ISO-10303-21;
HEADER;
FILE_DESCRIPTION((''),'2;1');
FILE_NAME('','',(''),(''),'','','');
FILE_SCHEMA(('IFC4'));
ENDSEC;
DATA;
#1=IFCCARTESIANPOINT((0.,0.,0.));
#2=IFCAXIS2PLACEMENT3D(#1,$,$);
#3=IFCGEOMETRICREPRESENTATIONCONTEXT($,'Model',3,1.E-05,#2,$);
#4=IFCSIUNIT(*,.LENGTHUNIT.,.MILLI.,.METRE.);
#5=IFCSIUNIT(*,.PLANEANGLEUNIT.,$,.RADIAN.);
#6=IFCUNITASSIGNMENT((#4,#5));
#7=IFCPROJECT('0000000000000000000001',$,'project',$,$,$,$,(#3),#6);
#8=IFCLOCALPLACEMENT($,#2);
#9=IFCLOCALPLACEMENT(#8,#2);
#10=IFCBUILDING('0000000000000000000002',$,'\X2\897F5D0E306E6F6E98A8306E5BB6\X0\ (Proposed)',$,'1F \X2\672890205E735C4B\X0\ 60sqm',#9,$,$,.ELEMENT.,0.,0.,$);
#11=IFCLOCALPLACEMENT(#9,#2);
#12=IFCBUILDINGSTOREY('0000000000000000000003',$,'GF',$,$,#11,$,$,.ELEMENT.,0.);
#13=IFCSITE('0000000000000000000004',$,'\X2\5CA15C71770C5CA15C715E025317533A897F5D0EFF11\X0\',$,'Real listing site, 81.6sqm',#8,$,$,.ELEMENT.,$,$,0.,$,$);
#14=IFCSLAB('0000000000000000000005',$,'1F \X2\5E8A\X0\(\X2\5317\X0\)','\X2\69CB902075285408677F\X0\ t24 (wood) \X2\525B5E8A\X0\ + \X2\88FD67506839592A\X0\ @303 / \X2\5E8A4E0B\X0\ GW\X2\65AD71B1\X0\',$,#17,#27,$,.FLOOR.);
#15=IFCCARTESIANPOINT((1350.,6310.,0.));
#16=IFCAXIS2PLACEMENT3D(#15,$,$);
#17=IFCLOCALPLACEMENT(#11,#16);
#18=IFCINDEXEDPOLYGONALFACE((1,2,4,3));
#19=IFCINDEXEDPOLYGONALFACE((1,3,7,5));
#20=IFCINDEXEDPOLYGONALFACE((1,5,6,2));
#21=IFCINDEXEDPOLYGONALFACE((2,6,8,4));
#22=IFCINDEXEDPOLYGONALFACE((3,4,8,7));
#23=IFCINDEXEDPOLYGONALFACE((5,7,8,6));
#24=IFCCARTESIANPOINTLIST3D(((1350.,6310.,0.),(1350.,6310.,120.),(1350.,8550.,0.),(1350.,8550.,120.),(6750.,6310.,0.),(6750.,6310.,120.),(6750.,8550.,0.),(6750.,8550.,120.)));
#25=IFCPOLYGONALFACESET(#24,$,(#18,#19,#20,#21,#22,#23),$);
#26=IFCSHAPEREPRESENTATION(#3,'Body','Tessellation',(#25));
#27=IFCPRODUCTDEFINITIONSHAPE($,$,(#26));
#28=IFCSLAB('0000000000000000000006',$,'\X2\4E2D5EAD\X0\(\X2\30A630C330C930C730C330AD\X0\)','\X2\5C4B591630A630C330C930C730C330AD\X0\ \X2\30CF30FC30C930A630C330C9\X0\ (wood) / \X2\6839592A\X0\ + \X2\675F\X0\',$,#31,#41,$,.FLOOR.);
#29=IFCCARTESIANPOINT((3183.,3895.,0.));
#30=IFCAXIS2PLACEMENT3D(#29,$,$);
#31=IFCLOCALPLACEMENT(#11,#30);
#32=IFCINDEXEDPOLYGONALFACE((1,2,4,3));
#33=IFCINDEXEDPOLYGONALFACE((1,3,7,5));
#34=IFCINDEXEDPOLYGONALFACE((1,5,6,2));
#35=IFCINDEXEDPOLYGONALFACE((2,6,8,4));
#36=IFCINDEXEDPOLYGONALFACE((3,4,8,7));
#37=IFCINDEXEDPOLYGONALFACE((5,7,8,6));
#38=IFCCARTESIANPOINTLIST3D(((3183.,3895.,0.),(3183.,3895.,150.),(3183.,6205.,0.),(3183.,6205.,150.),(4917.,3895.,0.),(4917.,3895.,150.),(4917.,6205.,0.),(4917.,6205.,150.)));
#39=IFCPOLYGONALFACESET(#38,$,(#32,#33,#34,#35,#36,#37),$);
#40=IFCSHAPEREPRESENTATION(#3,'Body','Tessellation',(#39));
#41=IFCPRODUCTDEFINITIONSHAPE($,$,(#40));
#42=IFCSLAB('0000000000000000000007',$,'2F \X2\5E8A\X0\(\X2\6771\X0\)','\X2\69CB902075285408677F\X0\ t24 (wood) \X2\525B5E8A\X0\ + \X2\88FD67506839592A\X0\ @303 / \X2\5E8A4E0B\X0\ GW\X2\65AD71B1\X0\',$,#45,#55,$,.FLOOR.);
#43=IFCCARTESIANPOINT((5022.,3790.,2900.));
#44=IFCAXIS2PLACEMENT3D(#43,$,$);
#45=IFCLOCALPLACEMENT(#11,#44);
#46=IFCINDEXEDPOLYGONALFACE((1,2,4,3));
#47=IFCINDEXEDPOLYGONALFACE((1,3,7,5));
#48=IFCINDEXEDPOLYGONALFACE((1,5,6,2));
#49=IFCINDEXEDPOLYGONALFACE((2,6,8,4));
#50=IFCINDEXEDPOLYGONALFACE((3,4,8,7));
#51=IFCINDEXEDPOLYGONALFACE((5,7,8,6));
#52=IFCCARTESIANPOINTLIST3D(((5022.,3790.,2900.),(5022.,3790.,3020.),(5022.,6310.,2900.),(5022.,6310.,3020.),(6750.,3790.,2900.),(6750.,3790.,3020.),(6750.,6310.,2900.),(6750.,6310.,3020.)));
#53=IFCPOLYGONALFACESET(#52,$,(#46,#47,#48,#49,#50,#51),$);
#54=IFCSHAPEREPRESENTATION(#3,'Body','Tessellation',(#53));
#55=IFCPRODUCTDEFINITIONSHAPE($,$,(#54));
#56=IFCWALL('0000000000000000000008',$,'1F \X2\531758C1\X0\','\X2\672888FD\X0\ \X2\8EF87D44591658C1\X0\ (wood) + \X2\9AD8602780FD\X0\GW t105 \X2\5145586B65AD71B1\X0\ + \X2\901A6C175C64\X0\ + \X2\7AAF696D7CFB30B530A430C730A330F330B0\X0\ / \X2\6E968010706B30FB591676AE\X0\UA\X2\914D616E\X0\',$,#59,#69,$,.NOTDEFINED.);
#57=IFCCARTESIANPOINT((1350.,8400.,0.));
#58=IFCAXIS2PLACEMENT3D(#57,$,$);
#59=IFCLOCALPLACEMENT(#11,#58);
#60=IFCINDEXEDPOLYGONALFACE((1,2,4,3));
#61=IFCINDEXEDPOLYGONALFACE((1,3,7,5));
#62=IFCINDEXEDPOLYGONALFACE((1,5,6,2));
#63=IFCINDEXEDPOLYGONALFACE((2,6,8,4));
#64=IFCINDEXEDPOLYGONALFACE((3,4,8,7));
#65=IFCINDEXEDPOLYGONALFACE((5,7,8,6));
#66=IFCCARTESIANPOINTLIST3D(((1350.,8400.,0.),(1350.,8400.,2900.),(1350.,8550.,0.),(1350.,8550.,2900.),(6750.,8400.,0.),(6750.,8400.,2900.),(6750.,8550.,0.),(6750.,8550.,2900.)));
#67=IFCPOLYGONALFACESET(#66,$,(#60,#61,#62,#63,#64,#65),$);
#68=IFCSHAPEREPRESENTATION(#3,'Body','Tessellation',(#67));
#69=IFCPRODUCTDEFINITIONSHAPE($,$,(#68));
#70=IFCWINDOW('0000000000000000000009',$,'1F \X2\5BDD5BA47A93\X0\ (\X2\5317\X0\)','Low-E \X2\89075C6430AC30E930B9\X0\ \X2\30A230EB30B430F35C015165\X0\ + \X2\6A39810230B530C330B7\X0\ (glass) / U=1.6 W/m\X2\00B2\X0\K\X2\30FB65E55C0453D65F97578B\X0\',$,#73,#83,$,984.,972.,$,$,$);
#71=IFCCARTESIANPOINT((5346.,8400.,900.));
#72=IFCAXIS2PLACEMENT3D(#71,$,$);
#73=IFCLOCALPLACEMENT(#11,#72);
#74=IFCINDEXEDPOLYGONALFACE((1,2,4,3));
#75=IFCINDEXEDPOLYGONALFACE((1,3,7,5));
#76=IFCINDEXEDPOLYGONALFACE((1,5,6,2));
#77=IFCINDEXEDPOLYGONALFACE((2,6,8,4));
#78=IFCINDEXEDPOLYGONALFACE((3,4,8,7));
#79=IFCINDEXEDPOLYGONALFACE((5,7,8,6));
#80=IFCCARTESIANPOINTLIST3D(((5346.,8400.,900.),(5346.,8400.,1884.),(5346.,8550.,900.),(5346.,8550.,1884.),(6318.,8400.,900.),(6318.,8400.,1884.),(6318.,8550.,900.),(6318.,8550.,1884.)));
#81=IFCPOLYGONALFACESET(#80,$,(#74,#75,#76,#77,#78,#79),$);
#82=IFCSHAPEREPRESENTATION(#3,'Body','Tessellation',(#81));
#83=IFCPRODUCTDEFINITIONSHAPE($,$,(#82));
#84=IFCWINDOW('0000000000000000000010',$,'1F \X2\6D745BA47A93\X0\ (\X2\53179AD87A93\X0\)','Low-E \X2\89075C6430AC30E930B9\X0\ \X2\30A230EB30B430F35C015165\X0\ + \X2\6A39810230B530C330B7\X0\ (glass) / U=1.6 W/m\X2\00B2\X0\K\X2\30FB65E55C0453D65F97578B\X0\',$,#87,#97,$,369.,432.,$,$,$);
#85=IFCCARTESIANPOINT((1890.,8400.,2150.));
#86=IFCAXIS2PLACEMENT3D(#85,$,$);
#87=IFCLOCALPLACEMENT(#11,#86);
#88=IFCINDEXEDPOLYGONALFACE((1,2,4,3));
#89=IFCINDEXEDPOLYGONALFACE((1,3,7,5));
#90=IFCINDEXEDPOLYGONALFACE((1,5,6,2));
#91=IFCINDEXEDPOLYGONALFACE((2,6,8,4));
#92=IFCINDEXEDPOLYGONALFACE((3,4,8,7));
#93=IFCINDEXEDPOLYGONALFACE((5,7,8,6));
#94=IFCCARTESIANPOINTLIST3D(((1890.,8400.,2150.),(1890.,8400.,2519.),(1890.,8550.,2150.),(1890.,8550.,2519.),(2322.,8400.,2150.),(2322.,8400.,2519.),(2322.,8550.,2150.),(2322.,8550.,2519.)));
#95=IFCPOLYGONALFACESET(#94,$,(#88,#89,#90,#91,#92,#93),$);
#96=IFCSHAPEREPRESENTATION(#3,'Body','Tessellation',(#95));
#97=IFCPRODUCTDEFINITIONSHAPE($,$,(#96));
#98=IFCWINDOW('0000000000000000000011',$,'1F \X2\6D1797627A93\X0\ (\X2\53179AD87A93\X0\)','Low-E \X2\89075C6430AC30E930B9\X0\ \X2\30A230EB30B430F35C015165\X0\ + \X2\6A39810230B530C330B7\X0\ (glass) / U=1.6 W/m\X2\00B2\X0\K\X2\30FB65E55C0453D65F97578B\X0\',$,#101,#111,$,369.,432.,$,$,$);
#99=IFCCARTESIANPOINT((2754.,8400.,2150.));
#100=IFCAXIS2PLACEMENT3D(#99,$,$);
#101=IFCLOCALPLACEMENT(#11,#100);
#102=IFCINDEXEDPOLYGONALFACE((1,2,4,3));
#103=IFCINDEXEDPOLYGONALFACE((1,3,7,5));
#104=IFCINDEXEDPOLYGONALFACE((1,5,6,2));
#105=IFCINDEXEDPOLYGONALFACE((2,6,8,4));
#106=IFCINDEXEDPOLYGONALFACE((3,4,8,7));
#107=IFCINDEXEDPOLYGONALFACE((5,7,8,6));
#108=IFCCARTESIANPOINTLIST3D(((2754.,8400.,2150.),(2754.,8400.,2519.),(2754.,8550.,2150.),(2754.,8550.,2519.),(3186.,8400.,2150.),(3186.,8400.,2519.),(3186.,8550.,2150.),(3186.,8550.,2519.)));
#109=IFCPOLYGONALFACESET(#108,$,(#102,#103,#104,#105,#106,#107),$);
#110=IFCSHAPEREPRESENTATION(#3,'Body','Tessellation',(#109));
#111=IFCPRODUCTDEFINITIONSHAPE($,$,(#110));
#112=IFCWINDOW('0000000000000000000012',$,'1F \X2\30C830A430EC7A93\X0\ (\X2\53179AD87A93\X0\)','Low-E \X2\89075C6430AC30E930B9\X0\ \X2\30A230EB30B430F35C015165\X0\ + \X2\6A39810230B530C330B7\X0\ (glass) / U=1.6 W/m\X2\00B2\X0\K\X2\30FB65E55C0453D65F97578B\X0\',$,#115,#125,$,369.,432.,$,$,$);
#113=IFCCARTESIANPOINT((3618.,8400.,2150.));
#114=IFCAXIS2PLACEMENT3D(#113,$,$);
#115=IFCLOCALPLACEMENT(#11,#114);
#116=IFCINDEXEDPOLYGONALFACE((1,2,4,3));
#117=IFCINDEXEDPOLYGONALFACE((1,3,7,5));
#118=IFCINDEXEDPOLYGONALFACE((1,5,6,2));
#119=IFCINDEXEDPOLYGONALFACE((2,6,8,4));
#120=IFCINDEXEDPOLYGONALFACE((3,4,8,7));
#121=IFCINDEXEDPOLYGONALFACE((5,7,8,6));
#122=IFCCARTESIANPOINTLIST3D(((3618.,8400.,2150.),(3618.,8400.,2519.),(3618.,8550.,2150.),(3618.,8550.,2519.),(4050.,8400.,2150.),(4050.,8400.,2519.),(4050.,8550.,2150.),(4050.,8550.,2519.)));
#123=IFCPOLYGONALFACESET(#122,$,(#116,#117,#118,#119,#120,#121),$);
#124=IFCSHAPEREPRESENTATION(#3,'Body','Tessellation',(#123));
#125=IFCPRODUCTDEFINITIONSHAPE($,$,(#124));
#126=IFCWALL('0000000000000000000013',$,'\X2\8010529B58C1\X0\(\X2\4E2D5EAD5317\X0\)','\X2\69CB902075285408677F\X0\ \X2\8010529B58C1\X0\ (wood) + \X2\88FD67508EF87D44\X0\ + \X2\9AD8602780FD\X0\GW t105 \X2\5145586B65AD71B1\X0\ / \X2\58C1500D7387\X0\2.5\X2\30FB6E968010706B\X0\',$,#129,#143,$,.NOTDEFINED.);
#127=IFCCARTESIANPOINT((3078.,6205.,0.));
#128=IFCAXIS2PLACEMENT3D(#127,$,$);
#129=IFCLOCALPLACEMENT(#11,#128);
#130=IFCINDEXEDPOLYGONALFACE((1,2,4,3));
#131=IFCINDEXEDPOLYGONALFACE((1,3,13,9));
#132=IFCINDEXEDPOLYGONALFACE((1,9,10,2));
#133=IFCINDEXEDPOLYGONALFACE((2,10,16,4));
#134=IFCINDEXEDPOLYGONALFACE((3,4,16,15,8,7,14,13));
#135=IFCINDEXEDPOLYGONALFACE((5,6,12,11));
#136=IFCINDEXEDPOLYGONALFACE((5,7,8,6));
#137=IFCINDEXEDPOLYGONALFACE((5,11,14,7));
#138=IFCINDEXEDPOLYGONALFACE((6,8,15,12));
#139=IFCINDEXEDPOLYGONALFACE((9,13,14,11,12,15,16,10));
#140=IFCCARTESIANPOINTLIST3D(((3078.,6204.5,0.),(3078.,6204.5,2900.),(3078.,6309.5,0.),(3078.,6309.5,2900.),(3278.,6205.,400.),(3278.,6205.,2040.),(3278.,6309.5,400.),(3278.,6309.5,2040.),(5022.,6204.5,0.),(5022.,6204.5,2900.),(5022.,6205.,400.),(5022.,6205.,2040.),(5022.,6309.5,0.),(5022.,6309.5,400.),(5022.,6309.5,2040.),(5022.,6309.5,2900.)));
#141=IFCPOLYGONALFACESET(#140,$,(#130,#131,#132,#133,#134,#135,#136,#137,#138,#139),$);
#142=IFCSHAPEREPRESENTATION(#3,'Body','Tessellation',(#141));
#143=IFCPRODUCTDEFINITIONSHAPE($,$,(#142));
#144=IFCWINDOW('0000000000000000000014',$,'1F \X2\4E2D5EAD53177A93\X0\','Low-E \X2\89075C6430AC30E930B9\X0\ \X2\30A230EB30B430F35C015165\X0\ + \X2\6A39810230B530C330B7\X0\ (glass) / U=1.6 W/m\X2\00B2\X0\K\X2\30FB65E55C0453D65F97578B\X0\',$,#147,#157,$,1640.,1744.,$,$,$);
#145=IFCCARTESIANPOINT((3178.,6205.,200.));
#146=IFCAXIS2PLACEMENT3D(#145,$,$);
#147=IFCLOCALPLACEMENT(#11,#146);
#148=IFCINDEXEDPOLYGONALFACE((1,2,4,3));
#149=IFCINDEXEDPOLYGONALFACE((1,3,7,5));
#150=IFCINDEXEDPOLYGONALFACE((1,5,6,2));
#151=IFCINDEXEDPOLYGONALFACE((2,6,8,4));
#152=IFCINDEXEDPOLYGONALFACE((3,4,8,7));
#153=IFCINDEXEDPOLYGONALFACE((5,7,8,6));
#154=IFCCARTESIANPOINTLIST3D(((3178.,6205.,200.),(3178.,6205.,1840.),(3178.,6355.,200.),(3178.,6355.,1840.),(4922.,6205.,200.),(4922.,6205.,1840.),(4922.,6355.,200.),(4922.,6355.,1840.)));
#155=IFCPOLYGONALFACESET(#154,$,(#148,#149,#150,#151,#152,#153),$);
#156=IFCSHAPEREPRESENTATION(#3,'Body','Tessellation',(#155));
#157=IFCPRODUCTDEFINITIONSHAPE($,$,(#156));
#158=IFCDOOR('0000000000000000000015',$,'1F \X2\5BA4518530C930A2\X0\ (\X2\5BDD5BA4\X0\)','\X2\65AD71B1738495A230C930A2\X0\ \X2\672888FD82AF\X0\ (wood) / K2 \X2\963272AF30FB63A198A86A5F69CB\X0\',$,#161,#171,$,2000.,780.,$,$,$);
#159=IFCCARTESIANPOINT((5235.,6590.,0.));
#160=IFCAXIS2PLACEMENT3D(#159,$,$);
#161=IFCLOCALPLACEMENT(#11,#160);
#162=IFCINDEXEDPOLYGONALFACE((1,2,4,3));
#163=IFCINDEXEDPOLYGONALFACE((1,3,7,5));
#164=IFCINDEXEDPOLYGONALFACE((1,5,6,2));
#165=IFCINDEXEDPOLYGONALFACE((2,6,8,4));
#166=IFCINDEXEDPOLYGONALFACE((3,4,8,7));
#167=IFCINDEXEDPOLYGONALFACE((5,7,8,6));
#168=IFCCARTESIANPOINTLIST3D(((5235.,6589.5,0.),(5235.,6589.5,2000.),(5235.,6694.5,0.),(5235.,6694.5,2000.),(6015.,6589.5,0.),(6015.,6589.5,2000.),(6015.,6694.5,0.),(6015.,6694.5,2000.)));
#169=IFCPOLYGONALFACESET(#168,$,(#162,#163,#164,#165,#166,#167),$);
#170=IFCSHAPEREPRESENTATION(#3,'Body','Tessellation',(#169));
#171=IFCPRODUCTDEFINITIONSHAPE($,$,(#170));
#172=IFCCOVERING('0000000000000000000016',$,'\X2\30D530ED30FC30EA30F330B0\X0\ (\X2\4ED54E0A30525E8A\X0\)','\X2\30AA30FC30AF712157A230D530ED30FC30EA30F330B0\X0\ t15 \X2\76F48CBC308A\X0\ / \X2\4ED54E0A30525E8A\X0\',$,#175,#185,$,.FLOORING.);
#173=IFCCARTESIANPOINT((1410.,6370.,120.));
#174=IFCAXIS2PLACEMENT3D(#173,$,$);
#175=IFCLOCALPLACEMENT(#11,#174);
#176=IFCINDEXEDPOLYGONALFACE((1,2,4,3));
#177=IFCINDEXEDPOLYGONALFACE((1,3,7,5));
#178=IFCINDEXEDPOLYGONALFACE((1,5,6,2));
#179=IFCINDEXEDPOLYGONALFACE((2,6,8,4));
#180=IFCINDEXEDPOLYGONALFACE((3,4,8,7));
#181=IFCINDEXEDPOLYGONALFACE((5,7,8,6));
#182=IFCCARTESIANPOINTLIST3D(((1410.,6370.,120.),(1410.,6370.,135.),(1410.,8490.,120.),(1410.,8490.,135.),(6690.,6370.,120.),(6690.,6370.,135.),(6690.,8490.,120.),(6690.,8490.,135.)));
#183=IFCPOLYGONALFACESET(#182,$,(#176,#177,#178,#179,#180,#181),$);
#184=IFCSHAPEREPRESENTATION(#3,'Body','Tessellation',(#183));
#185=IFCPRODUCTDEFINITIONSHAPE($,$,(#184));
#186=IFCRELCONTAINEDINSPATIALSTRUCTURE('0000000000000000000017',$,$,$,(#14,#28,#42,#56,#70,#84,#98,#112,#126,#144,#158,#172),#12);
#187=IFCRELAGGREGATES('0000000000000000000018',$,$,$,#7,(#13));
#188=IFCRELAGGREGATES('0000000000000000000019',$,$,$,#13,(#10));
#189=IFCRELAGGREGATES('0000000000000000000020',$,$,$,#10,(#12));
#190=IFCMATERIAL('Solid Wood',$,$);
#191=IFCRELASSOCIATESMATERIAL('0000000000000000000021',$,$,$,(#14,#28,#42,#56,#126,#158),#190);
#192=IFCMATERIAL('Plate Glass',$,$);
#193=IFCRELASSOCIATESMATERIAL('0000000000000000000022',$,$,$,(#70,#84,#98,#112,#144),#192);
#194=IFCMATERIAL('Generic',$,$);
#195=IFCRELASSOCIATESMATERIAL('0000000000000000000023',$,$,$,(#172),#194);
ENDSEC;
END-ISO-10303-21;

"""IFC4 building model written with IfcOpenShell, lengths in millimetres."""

from ifc_helpers import new_model, si_unit, frame, frame_2d, origin, place, context, project, spatial, rectangle, extrude, material, element, fill, save


model = new_model("IFC4")

# Units and contexts
model_context = context("Model", 3, precision=1e-05, world=origin())
ifc_project = project(units=[si_unit("LENGTHUNIT", "METRE", prefix="MILLI"), si_unit("PLANEANGLEUNIT", "RADIAN")], contexts=[model_context])

# Site, building, storey
site_placement = place(None, origin())
site = spatial("IfcSite", under=ifc_project, at=site_placement, Name="岡山県岡山市北区西崎１", ObjectType="Real listing site, 81.6sqm", CompositionType="ELEMENT", RefElevation=0.0)
building_placement = place(site_placement, origin())
building = spatial("IfcBuilding", under=site, at=building_placement, Name="西崎の潮風の家 (Proposed)", ObjectType="1F 木造平屋 60sqm", CompositionType="ELEMENT", ElevationOfRefHeight=0.0, ElevationOfTerrain=0.0)
storey_placement = place(building_placement, origin())
storey = spatial("IfcBuildingStorey", under=building, at=storey_placement, Name="GF", CompositionType="ELEMENT", Elevation=0.0)

# Slabs
ifc_material_1 = material(Name="Solid Wood")
slab_1_placement = place(storey_placement, frame((1350.0, 6310.0, 0.0)))
element("IfcSlab", 1, at=slab_1_placement, inside=storey, material=ifc_material_1, Name="1F 床(北)", Description="構造用合板 t24 (wood) 剛床 + 製材根太 @303 / 床下 GW断熱", PredefinedType="FLOOR", context=model_context, shape_type="SweptSolid", body=[
    extrude(rectangle(XDim=5400.0, YDim=2240.0, at=frame_2d((2700.0, 1120.0))), frame((1350.0, 6310.0, 0.0)), (0.0, 0.0, 1.0), 120.0),
])
slab_2_placement = place(storey_placement, frame((3183.0, 3895.0, 0.0)))
element("IfcSlab", 2, at=slab_2_placement, inside=storey, material=ifc_material_1, Name="中庭(ウッドデッキ)", Description="屋外ウッドデッキ ハードウッド (wood) / 根太 + 束", PredefinedType="FLOOR", context=model_context, shape_type="SweptSolid", body=[
    extrude(rectangle(XDim=1734.0, YDim=2310.0, at=frame_2d((867.0, 1155.0))), frame((3183.0, 3895.0, 0.0)), (0.0, 0.0, 1.0), 150.0),
])
slab_3_placement = place(storey_placement, frame((5022.0, 3790.0, 2900.0)))
element("IfcSlab", 3, at=slab_3_placement, inside=storey, material=ifc_material_1, Name="2F 床(東)", Description="構造用合板 t24 (wood) 剛床 + 製材根太 @303 / 床下 GW断熱", PredefinedType="FLOOR", context=model_context, shape_type="SweptSolid", body=[
    extrude(rectangle(XDim=1728.0, YDim=2520.0, at=frame_2d((864.0, 1260.0))), frame((5022.0, 3790.0, 2900.0)), (0.0, 0.0, 1.0), 120.0),
])

# Wall, openings, windows
wall_1_placement = place(storey_placement, frame((1350.0, 8400.0, 0.0)))
wall_1 = element("IfcWall", 4, at=wall_1_placement, inside=storey, material=ifc_material_1, Name="1F 北壁", Description="木製 軸組外壁 (wood) + 高性能GW t105 充填断熱 + 通気層 + 窯業系サイディング / 準耐火・外皮UA配慮", PredefinedType="NOTDEFINED", context=model_context, shape_type="SweptSolid", body=[
    extrude(rectangle(XDim=5400.0, YDim=150.0, at=frame_2d((2700.0, 75.0))), frame((1350.0, 8400.0, 0.0)), (0.0, 0.0, 1.0), 2900.0),
])
opening_1_placement = place(storey_placement, frame((5346.0, 8400.0, 900.0)))
opening_1 = element("IfcOpeningElement", 5, at=opening_1_placement, cuts=wall_1, PredefinedType="NOTDEFINED", context=model_context, shape_type="SweptSolid", body=[
    extrude(rectangle(XDim=972.0, YDim=150.0, at=frame_2d((486.0, 75.0))), frame((5346.0, 8400.0, 900.0)), (0.0, 0.0, 1.0), 984.0),
])
opening_2_placement = place(storey_placement, frame((1890.0, 8400.0, 2150.0)))
opening_2 = element("IfcOpeningElement", 6, at=opening_2_placement, cuts=wall_1, PredefinedType="NOTDEFINED", context=model_context, shape_type="SweptSolid", body=[
    extrude(rectangle(XDim=432.0, YDim=150.0, at=frame_2d((216.0, 75.0))), frame((1890.0, 8400.0, 2150.0)), (0.0, 0.0, 1.0), 369.0),
])
opening_3_placement = place(storey_placement, frame((2754.0, 8400.0, 2150.0)))
opening_3 = element("IfcOpeningElement", 7, at=opening_3_placement, cuts=wall_1, PredefinedType="NOTDEFINED", context=model_context, shape_type="SweptSolid", body=[
    extrude(rectangle(XDim=432.0, YDim=150.0, at=frame_2d((216.0, 75.0))), frame((2754.0, 8400.0, 2150.0)), (0.0, 0.0, 1.0), 369.0),
])
opening_4_placement = place(storey_placement, frame((3618.0, 8400.0, 2150.0)))
opening_4 = element("IfcOpeningElement", 8, at=opening_4_placement, cuts=wall_1, PredefinedType="NOTDEFINED", context=model_context, shape_type="SweptSolid", body=[
    extrude(rectangle(XDim=432.0, YDim=150.0, at=frame_2d((216.0, 75.0))), frame((3618.0, 8400.0, 2150.0)), (0.0, 0.0, 1.0), 369.0),
])
ifc_material_2 = material(Name="Plate Glass")
window_1_placement = place(storey_placement, frame((5346.0, 8400.0, 900.0)))
window_1 = element("IfcWindow", 9, at=window_1_placement, inside=storey, material=ifc_material_2, Name="1F 寝室窓 (北)", Description="Low-E 複層ガラス アルゴン封入 + 樹脂サッシ (glass) / U=1.6 W/m²K・日射取得型", OverallHeight=984.0, OverallWidth=972.0, context=model_context, shape_type="SweptSolid", body=[
    extrude(rectangle(XDim=972.0, YDim=150.0, at=frame_2d((486.0, 75.0))), frame((5346.0, 8400.0, 900.0)), (0.0, 0.0, 1.0), 984.0),
])
fill(opening_1, window_1)
window_2_placement = place(storey_placement, frame((1890.0, 8400.0, 2150.0)))
window_2 = element("IfcWindow", 10, at=window_2_placement, inside=storey, material=ifc_material_2, Name="1F 浴室窓 (北高窓)", Description="Low-E 複層ガラス アルゴン封入 + 樹脂サッシ (glass) / U=1.6 W/m²K・日射取得型", OverallHeight=369.0, OverallWidth=432.0, context=model_context, shape_type="SweptSolid", body=[
    extrude(rectangle(XDim=432.0, YDim=150.0, at=frame_2d((216.0, 75.0))), frame((1890.0, 8400.0, 2150.0)), (0.0, 0.0, 1.0), 369.0),
])
fill(opening_2, window_2)
window_3_placement = place(storey_placement, frame((2754.0, 8400.0, 2150.0)))
window_3 = element("IfcWindow", 11, at=window_3_placement, inside=storey, material=ifc_material_2, Name="1F 洗面窓 (北高窓)", Description="Low-E 複層ガラス アルゴン封入 + 樹脂サッシ (glass) / U=1.6 W/m²K・日射取得型", OverallHeight=369.0, OverallWidth=432.0, context=model_context, shape_type="SweptSolid", body=[
    extrude(rectangle(XDim=432.0, YDim=150.0, at=frame_2d((216.0, 75.0))), frame((2754.0, 8400.0, 2150.0)), (0.0, 0.0, 1.0), 369.0),
])
fill(opening_3, window_3)
window_4_placement = place(storey_placement, frame((3618.0, 8400.0, 2150.0)))
window_4 = element("IfcWindow", 12, at=window_4_placement, inside=storey, material=ifc_material_2, Name="1F トイレ窓 (北高窓)", Description="Low-E 複層ガラス アルゴン封入 + 樹脂サッシ (glass) / U=1.6 W/m²K・日射取得型", OverallHeight=369.0, OverallWidth=432.0, context=model_context, shape_type="SweptSolid", body=[
    extrude(rectangle(XDim=432.0, YDim=150.0, at=frame_2d((216.0, 75.0))), frame((3618.0, 8400.0, 2150.0)), (0.0, 0.0, 1.0), 369.0),
])
fill(opening_4, window_4)

# Wall, opening, window
wall_2_placement = place(storey_placement, frame((3078.0, 6205.0, 0.0)))
wall_2 = element("IfcWall", 13, at=wall_2_placement, inside=storey, material=ifc_material_1, Name="耐力壁(中庭北)", Description="構造用合板 耐力壁 (wood) + 製材軸組 + 高性能GW t105 充填断熱 / 壁倍率2.5・準耐火", PredefinedType="NOTDEFINED", context=model_context, shape_type="SweptSolid", body=[
    extrude(rectangle(XDim=1944.0, YDim=105.0, at=frame_2d((972.0, 52.0))), frame((3078.0, 6205.0, 0.0)), (0.0, 0.0, 1.0), 2900.0),
])
opening_5_placement = place(storey_placement, frame((3178.0, 6205.0, 200.0)))
opening_5 = element("IfcOpeningElement", 14, at=opening_5_placement, cuts=wall_2, PredefinedType="NOTDEFINED", context=model_context, shape_type="SweptSolid", body=[
    extrude(rectangle(XDim=1744.0, YDim=150.0, at=frame_2d((872.0, 75.0))), frame((3178.0, 6205.0, 200.0)), (0.0, 0.0, 1.0), 1640.0),
])
window_5_placement = place(storey_placement, frame((3178.0, 6205.0, 200.0)))
window_5 = element("IfcWindow", 15, at=window_5_placement, inside=storey, material=ifc_material_2, Name="1F 中庭北窓", Description="Low-E 複層ガラス アルゴン封入 + 樹脂サッシ (glass) / U=1.6 W/m²K・日射取得型", OverallHeight=1640.0, OverallWidth=1744.0, context=model_context, shape_type="SweptSolid", body=[
    extrude(rectangle(XDim=1744.0, YDim=150.0, at=frame_2d((872.0, 75.0))), frame((3178.0, 6205.0, 200.0)), (0.0, 0.0, 1.0), 1640.0),
])
fill(opening_5, window_5)

# Door
door_1_placement = place(storey_placement, frame((5235.0, 6590.0, 0.0)))
element("IfcDoor", 16, at=door_1_placement, inside=storey, material=ifc_material_1, Name="1F 室内ドア (寝室)", Description="断熱玄関ドア 木製芯 (wood) / K2 防犯・採風機構", OverallHeight=2000.0, OverallWidth=780.0, context=model_context, shape_type="SweptSolid", body=[
    extrude(rectangle(XDim=780.0, YDim=105.0, at=frame_2d((390.0, 52.0))), frame((5235.0, 6590.0, 0.0)), (0.0, 0.0, 1.0), 2000.0),
])

# Covering
ifc_material_3 = material(Name="Generic")
covering_1_placement = place(storey_placement, frame((1410.0, 6370.0, 120.0)))
element("IfcCovering", 17, at=covering_1_placement, inside=storey, material=ifc_material_3, Name="フローリング (仕上げ床)", Description="オーク無垢フローリング t15 直貼り / 仕上げ床", PredefinedType="FLOORING", context=model_context, shape_type="SweptSolid", body=[
    extrude(rectangle(XDim=5280.0, YDim=2120.0, at=frame_2d((2640.0, 1060.0))), frame((1410.0, 6370.0, 120.0)), (0.0, 0.0, 1.0), 15.0),
])

save(model, "model.ifc")
